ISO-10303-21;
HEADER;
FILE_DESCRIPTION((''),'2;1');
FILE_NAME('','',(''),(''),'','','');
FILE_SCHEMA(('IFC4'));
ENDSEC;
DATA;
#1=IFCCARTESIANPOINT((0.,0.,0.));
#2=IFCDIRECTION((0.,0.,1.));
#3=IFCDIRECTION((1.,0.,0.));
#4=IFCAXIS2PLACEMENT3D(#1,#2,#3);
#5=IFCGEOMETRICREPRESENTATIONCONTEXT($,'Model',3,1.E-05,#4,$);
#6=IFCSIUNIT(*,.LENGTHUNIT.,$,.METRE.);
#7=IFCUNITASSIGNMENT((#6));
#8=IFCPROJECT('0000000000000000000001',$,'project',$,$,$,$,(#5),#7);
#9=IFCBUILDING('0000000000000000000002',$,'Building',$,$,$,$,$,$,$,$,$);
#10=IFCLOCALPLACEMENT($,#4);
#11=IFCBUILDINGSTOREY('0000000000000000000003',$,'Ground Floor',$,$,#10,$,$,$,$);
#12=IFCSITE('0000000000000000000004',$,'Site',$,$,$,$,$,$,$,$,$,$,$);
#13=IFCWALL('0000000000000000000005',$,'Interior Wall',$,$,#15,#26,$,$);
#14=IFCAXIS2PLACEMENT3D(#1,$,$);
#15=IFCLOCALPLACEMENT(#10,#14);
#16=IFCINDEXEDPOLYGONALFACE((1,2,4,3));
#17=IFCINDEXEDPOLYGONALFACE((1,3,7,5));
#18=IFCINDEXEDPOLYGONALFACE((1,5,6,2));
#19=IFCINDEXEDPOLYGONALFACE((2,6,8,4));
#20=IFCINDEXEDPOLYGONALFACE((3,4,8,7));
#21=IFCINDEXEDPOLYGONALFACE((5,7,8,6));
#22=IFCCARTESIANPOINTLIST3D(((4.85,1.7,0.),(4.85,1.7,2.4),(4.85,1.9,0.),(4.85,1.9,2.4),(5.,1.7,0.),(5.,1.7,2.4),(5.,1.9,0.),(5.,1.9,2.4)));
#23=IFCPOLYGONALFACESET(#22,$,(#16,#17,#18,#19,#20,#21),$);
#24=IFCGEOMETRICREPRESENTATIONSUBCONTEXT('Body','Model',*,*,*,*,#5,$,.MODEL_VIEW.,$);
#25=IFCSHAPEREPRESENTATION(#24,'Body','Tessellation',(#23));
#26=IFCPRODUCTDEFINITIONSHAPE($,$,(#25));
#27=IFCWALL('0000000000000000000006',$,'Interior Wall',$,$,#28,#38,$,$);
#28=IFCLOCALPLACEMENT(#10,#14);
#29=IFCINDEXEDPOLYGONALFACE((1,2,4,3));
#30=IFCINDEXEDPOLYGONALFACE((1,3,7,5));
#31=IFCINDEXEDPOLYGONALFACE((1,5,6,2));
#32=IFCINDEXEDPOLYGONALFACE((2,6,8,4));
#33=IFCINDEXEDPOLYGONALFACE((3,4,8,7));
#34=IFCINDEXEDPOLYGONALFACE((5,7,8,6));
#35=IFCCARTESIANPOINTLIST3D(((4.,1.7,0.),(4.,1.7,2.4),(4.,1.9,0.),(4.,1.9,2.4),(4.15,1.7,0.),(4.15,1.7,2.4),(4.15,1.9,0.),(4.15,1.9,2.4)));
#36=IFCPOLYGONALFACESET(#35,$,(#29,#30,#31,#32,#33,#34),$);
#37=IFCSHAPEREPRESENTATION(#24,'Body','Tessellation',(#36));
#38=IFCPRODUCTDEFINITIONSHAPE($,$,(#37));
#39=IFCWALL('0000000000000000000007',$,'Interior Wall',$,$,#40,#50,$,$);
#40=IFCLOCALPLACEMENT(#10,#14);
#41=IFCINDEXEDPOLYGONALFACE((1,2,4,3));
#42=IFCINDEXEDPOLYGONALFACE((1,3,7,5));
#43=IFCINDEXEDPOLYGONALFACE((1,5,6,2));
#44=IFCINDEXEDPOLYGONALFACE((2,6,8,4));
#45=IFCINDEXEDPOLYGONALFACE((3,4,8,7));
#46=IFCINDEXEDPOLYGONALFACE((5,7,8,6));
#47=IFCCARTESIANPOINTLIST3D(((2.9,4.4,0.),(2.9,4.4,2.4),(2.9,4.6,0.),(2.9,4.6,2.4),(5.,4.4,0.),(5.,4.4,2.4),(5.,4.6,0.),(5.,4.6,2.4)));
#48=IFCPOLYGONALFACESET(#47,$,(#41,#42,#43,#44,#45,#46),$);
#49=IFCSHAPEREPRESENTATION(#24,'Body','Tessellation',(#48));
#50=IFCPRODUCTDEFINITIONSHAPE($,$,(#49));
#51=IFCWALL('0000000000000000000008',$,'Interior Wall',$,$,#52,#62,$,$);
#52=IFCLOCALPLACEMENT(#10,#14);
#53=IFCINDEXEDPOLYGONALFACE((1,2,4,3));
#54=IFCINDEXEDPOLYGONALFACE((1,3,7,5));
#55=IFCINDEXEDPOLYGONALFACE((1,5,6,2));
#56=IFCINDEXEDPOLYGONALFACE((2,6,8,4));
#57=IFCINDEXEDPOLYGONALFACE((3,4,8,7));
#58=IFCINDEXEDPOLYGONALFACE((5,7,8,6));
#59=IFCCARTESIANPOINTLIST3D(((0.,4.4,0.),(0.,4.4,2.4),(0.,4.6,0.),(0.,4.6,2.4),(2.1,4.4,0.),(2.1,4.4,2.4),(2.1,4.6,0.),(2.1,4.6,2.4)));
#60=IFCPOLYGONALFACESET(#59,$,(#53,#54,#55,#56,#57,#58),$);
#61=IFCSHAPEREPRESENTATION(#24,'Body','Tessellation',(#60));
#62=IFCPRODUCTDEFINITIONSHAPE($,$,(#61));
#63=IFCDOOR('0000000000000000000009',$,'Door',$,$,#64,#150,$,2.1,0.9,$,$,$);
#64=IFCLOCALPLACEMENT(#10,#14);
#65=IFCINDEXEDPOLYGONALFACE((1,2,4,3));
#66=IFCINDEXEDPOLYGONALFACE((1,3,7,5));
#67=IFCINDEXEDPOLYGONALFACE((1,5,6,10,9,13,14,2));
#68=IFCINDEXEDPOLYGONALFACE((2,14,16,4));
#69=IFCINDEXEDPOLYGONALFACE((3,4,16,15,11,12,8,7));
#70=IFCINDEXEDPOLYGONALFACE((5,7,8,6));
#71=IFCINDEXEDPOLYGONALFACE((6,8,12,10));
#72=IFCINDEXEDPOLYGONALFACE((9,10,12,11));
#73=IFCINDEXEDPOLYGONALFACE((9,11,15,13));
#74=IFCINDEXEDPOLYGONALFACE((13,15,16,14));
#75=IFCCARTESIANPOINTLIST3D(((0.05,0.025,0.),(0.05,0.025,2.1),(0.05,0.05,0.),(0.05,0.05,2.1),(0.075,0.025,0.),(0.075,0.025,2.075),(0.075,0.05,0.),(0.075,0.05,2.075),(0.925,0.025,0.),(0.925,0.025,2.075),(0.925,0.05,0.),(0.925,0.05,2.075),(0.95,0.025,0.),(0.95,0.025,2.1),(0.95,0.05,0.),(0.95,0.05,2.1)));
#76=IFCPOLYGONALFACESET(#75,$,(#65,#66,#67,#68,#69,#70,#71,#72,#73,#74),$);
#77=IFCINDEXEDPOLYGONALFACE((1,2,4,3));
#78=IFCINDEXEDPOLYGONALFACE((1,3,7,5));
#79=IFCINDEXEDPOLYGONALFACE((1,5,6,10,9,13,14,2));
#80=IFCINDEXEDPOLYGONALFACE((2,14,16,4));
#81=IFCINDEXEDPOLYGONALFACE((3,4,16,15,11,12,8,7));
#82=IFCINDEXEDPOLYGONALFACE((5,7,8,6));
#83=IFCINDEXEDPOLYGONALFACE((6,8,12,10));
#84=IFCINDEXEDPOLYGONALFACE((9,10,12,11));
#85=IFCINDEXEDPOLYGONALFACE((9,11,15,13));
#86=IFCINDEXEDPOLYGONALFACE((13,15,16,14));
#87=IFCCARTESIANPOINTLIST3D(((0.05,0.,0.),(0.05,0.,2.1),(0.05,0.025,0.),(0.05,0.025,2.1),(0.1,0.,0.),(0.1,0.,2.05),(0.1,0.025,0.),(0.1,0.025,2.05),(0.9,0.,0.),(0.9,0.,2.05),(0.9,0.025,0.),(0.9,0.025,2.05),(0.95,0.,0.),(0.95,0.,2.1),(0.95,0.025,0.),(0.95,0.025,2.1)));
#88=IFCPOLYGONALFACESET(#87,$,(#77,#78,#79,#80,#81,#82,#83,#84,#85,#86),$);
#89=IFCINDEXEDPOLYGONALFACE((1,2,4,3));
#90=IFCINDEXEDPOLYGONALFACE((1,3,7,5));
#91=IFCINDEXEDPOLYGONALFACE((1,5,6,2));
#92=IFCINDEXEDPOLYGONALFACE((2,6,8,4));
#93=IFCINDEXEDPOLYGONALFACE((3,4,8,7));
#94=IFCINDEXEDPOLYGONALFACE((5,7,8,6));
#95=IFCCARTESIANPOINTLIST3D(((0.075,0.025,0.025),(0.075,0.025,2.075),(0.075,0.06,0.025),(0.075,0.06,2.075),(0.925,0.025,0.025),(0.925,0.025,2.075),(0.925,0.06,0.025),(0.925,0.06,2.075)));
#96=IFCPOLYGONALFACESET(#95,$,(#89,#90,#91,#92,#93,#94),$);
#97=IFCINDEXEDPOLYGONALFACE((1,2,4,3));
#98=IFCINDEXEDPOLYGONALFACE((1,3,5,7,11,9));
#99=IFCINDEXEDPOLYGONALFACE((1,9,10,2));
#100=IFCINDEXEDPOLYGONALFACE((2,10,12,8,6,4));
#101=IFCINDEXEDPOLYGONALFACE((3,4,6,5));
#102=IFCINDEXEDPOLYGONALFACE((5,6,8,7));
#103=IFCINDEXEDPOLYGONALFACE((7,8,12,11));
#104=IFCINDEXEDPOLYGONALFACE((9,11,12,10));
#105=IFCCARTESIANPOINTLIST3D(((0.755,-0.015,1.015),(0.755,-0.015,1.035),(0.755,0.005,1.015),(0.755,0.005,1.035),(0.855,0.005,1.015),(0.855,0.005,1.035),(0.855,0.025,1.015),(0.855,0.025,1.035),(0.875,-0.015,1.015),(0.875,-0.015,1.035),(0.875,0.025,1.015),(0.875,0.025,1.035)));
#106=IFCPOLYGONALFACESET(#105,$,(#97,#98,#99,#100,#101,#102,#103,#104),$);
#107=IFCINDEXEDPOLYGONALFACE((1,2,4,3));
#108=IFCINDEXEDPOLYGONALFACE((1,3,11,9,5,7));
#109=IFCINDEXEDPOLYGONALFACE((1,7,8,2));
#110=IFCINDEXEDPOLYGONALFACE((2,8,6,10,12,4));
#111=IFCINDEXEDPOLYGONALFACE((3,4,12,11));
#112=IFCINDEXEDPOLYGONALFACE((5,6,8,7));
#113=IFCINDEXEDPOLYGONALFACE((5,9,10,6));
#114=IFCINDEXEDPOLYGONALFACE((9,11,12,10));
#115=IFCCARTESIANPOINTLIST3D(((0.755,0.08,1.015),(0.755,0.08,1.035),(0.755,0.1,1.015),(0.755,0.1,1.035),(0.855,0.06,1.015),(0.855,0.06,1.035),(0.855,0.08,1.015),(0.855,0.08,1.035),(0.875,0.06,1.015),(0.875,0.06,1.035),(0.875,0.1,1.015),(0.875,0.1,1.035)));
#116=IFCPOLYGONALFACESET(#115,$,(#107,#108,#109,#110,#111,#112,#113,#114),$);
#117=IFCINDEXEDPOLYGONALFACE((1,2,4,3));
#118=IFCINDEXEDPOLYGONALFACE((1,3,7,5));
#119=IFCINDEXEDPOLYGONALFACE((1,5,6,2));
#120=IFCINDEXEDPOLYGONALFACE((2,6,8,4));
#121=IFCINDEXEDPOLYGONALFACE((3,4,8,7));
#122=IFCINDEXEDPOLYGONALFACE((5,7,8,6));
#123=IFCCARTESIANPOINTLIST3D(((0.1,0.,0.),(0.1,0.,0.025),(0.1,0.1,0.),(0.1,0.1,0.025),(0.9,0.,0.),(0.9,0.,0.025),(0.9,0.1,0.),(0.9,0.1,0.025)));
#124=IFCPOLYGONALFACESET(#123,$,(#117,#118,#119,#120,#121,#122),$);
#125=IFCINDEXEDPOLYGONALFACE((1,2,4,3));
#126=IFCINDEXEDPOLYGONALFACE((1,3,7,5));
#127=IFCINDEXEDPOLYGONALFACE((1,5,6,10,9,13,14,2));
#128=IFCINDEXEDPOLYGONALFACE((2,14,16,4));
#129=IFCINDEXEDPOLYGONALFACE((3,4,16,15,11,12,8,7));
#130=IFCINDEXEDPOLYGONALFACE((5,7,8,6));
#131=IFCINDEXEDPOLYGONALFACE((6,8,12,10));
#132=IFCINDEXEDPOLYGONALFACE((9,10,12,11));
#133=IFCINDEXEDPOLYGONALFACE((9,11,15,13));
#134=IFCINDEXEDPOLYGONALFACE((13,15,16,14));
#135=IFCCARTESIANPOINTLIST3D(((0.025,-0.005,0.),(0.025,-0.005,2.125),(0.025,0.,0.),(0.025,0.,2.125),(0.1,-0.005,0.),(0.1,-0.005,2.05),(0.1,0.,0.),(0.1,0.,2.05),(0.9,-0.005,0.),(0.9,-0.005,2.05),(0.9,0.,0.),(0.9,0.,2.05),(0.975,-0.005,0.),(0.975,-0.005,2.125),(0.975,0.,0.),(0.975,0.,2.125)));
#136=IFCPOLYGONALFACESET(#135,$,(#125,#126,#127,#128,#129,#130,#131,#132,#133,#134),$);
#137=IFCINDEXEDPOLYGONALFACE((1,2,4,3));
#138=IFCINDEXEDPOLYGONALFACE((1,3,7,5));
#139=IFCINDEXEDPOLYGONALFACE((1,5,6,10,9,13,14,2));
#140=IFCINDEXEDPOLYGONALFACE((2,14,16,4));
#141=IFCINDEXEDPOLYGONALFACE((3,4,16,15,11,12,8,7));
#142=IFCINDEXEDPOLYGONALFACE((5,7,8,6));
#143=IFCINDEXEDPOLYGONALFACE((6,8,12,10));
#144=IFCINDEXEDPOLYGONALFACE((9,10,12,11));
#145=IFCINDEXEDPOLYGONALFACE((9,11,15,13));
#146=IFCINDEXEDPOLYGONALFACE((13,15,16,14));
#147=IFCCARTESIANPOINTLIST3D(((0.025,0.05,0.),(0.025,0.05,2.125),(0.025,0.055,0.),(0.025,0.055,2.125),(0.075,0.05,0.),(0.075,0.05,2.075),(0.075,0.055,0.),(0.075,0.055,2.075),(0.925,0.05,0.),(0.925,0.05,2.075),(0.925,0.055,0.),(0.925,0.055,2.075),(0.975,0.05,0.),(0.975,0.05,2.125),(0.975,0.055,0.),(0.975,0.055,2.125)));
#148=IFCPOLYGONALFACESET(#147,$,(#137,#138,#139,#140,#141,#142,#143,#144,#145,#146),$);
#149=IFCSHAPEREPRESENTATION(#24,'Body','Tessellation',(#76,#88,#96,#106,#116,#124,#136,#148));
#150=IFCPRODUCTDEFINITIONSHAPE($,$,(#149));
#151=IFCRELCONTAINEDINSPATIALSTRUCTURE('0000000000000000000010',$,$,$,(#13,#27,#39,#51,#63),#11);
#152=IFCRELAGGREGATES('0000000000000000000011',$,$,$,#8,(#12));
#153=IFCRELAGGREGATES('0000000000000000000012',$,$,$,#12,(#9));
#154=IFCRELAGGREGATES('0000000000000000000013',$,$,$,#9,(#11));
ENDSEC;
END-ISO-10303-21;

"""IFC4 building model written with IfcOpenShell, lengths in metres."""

from ifc_helpers import new_model, si_unit, frame, origin_with_axes, place, context, subcontext, project, spatial, line, indexed_curve, outline, extrude, element, save


model = new_model("IFC4")

# Units and contexts
model_context = context("Model", 3, precision=1e-05, world=origin_with_axes())
body_context = subcontext(model_context, "Body", "Model", "MODEL_VIEW")
ifc_project = project(units=[si_unit("LENGTHUNIT", "METRE")], contexts=[model_context])

# Site, building, storey
site = spatial("IfcSite", under=ifc_project, Name="Site")
building = spatial("IfcBuilding", under=site, Name="Building")
storey_placement = place(None, origin_with_axes())
storey = spatial("IfcBuildingStorey", under=building, at=storey_placement, Name="Ground Floor")

# Walls
for number, where, z_axis, x_axis, name in (
    (1, (5.0, 1.8, 0.0), (0.0, 0.0, 1.0), (-1.0, 0.0, 0.0), "Interior Wall"),
    (2, (4.15, 1.8, 0.0), (0.0, 0.0, 1.0), (-1.0, 0.0, 0.0), "Interior Wall"),
):
    element("IfcWall", number, at=place(storey_placement, frame(where, z_axis=z_axis, x_axis=x_axis)), inside=storey, Name=name, context=body_context, shape_type="SweptSolid", body=[
        extrude(outline(indexed_curve([(0.0, 0.0), (0.0, 0.2), (0.15, 0.2), (0.15, 0.0), (0.0, 0.0)], self_intersect=False)), frame((0.0, -0.1, 0.0), z_axis=(0.0, 0.0, 1.0), x_axis=(1.0, 0.0, 0.0)), (0.0, 0.0, 1.0), 2.4),
    ])
for number, where, z_axis, x_axis, name in (
    (3, (5.0, 4.5, 0.0), (0.0, 0.0, 1.0), (-1.0, 0.0, 0.0), "Interior Wall"),
    (4, (2.1, 4.5, 0.0), (0.0, 0.0, 1.0), (-1.0, 0.0, 0.0), "Interior Wall"),
):
    element("IfcWall", number, at=place(storey_placement, frame(where, z_axis=z_axis, x_axis=x_axis)), inside=storey, Name=name, context=body_context, shape_type="SweptSolid", body=[
        extrude(outline(indexed_curve([(0.0, 0.0), (0.0, 0.2), (2.1, 0.2), (2.1, 0.0), (0.0, 0.0)], self_intersect=False)), frame((0.0, -0.1, 0.0), z_axis=(0.0, 0.0, 1.0), x_axis=(1.0, 0.0, 0.0)), (0.0, 0.0, 1.0), 2.4),
    ])

# Door
door_1_placement = place(storey_placement, frame((0.05, 0.0, 0.0), z_axis=(0.0, 0.0, 1.0), x_axis=(1.0, 0.0, 0.0)))
element("IfcDoor", 5, at=door_1_placement, inside=storey, Name="Door", OverallHeight=2.1, OverallWidth=0.9, context=body_context, shape_type="SweptSolid", body=[
    extrude(outline(indexed_curve([(0.0, 0.0), (0.0, 2.1), (0.9, 2.1), (0.9, 0.0), (0.875, 0.0), (0.875, 2.075), (0.025, 2.075), (0.025, 0.0)], segments=[line(1, 2, 3, 4, 5, 6, 7, 8, 1)])), frame((0.0, 0.025, 0.0), z_axis=(0.0, -1.0, 0.0), x_axis=(1.0, 0.0, 0.0)), (0.0, 0.0, -1.0), 0.025),
    extrude(outline(indexed_curve([(0.0, 0.0), (0.0, 2.1), (0.9, 2.1), (0.9, 0.0), (0.85, 0.0), (0.85, 2.05), (0.05, 2.05), (0.05, 0.0)], segments=[line(1, 2, 3, 4, 5, 6, 7, 8, 1)])), frame((0.0, 0.0, 0.0), z_axis=(0.0, -1.0, 0.0), x_axis=(1.0, 0.0, 0.0)), (0.0, 0.0, -1.0), 0.025),
    extrude(outline(indexed_curve([(0.0, 0.0), (0.85, 0.0), (0.85, 0.035), (0.0, 0.035)], segments=[line(1, 2, 3, 4, 1)])), frame((0.025, 0.025, 0.025), z_axis=(0.0, 0.0, 1.0), x_axis=(1.0, 0.0, 0.0)), (0.0, 0.0, 1.0), 2.05),
    extrude(outline(indexed_curve([(0.0, 0.0), (0.0, -0.04), (-0.12, -0.04), (-0.12, -0.02), (-0.02, -0.02), (-0.02, 0.0)], segments=[line(1, 2, 3, 4, 5, 6, 1)])), frame((0.825, 0.025, 1.015), z_axis=(0.0, 0.0, 1.0), x_axis=(1.0, 0.0, 0.0)), (0.0, 0.0, 1.0), 0.02),
    extrude(outline(indexed_curve([(0.0, 0.0), (0.0, 0.04), (-0.12, 0.04), (-0.12, 0.02), (-0.02, 0.02), (-0.02, 0.0)], segments=[line(1, 2, 3, 4, 5, 6, 1)])), frame((0.825, 0.06, 1.015), z_axis=(0.0, 0.0, 1.0), x_axis=(1.0, 0.0, 0.0)), (0.0, 0.0, 1.0), 0.02),
    extrude(outline(indexed_curve([(0.0, 0.0), (0.8, 0.0), (0.8, 0.1), (0.0, 0.1)], segments=[line(1, 2, 3, 4, 1)])), frame((0.05, 0.0, 0.0), z_axis=(0.0, 0.0, 1.0), x_axis=(1.0, 0.0, 0.0)), (0.0, 0.0, 1.0), 0.025),
    extrude(outline(indexed_curve([(0.0, 0.0), (0.0, 2.125), (0.95, 2.125), (0.95, 0.0), (0.875, 0.0), (0.875, 2.05), (0.075, 2.05), (0.075, 0.0)], segments=[line(1, 2, 3, 4, 5, 6, 7, 8, 1)])), frame((-0.025, -0.005, 0.0), z_axis=(0.0, -1.0, 0.0), x_axis=(1.0, 0.0, 0.0)), (0.0, 0.0, -1.0), 0.005),
    extrude(outline(indexed_curve([(0.0, 0.0), (0.0, 2.125), (0.95, 2.125), (0.95, 0.0), (0.9, 0.0), (0.9, 2.075), (0.05, 2.075), (0.05, 0.0)], segments=[line(1, 2, 3, 4, 5, 6, 7, 8, 1)])), frame((-0.025, 0.05, 0.0), z_axis=(0.0, -1.0, 0.0), x_axis=(1.0, 0.0, 0.0)), (0.0, 0.0, -1.0), 0.005),
])

save(model, "model.ifc")
